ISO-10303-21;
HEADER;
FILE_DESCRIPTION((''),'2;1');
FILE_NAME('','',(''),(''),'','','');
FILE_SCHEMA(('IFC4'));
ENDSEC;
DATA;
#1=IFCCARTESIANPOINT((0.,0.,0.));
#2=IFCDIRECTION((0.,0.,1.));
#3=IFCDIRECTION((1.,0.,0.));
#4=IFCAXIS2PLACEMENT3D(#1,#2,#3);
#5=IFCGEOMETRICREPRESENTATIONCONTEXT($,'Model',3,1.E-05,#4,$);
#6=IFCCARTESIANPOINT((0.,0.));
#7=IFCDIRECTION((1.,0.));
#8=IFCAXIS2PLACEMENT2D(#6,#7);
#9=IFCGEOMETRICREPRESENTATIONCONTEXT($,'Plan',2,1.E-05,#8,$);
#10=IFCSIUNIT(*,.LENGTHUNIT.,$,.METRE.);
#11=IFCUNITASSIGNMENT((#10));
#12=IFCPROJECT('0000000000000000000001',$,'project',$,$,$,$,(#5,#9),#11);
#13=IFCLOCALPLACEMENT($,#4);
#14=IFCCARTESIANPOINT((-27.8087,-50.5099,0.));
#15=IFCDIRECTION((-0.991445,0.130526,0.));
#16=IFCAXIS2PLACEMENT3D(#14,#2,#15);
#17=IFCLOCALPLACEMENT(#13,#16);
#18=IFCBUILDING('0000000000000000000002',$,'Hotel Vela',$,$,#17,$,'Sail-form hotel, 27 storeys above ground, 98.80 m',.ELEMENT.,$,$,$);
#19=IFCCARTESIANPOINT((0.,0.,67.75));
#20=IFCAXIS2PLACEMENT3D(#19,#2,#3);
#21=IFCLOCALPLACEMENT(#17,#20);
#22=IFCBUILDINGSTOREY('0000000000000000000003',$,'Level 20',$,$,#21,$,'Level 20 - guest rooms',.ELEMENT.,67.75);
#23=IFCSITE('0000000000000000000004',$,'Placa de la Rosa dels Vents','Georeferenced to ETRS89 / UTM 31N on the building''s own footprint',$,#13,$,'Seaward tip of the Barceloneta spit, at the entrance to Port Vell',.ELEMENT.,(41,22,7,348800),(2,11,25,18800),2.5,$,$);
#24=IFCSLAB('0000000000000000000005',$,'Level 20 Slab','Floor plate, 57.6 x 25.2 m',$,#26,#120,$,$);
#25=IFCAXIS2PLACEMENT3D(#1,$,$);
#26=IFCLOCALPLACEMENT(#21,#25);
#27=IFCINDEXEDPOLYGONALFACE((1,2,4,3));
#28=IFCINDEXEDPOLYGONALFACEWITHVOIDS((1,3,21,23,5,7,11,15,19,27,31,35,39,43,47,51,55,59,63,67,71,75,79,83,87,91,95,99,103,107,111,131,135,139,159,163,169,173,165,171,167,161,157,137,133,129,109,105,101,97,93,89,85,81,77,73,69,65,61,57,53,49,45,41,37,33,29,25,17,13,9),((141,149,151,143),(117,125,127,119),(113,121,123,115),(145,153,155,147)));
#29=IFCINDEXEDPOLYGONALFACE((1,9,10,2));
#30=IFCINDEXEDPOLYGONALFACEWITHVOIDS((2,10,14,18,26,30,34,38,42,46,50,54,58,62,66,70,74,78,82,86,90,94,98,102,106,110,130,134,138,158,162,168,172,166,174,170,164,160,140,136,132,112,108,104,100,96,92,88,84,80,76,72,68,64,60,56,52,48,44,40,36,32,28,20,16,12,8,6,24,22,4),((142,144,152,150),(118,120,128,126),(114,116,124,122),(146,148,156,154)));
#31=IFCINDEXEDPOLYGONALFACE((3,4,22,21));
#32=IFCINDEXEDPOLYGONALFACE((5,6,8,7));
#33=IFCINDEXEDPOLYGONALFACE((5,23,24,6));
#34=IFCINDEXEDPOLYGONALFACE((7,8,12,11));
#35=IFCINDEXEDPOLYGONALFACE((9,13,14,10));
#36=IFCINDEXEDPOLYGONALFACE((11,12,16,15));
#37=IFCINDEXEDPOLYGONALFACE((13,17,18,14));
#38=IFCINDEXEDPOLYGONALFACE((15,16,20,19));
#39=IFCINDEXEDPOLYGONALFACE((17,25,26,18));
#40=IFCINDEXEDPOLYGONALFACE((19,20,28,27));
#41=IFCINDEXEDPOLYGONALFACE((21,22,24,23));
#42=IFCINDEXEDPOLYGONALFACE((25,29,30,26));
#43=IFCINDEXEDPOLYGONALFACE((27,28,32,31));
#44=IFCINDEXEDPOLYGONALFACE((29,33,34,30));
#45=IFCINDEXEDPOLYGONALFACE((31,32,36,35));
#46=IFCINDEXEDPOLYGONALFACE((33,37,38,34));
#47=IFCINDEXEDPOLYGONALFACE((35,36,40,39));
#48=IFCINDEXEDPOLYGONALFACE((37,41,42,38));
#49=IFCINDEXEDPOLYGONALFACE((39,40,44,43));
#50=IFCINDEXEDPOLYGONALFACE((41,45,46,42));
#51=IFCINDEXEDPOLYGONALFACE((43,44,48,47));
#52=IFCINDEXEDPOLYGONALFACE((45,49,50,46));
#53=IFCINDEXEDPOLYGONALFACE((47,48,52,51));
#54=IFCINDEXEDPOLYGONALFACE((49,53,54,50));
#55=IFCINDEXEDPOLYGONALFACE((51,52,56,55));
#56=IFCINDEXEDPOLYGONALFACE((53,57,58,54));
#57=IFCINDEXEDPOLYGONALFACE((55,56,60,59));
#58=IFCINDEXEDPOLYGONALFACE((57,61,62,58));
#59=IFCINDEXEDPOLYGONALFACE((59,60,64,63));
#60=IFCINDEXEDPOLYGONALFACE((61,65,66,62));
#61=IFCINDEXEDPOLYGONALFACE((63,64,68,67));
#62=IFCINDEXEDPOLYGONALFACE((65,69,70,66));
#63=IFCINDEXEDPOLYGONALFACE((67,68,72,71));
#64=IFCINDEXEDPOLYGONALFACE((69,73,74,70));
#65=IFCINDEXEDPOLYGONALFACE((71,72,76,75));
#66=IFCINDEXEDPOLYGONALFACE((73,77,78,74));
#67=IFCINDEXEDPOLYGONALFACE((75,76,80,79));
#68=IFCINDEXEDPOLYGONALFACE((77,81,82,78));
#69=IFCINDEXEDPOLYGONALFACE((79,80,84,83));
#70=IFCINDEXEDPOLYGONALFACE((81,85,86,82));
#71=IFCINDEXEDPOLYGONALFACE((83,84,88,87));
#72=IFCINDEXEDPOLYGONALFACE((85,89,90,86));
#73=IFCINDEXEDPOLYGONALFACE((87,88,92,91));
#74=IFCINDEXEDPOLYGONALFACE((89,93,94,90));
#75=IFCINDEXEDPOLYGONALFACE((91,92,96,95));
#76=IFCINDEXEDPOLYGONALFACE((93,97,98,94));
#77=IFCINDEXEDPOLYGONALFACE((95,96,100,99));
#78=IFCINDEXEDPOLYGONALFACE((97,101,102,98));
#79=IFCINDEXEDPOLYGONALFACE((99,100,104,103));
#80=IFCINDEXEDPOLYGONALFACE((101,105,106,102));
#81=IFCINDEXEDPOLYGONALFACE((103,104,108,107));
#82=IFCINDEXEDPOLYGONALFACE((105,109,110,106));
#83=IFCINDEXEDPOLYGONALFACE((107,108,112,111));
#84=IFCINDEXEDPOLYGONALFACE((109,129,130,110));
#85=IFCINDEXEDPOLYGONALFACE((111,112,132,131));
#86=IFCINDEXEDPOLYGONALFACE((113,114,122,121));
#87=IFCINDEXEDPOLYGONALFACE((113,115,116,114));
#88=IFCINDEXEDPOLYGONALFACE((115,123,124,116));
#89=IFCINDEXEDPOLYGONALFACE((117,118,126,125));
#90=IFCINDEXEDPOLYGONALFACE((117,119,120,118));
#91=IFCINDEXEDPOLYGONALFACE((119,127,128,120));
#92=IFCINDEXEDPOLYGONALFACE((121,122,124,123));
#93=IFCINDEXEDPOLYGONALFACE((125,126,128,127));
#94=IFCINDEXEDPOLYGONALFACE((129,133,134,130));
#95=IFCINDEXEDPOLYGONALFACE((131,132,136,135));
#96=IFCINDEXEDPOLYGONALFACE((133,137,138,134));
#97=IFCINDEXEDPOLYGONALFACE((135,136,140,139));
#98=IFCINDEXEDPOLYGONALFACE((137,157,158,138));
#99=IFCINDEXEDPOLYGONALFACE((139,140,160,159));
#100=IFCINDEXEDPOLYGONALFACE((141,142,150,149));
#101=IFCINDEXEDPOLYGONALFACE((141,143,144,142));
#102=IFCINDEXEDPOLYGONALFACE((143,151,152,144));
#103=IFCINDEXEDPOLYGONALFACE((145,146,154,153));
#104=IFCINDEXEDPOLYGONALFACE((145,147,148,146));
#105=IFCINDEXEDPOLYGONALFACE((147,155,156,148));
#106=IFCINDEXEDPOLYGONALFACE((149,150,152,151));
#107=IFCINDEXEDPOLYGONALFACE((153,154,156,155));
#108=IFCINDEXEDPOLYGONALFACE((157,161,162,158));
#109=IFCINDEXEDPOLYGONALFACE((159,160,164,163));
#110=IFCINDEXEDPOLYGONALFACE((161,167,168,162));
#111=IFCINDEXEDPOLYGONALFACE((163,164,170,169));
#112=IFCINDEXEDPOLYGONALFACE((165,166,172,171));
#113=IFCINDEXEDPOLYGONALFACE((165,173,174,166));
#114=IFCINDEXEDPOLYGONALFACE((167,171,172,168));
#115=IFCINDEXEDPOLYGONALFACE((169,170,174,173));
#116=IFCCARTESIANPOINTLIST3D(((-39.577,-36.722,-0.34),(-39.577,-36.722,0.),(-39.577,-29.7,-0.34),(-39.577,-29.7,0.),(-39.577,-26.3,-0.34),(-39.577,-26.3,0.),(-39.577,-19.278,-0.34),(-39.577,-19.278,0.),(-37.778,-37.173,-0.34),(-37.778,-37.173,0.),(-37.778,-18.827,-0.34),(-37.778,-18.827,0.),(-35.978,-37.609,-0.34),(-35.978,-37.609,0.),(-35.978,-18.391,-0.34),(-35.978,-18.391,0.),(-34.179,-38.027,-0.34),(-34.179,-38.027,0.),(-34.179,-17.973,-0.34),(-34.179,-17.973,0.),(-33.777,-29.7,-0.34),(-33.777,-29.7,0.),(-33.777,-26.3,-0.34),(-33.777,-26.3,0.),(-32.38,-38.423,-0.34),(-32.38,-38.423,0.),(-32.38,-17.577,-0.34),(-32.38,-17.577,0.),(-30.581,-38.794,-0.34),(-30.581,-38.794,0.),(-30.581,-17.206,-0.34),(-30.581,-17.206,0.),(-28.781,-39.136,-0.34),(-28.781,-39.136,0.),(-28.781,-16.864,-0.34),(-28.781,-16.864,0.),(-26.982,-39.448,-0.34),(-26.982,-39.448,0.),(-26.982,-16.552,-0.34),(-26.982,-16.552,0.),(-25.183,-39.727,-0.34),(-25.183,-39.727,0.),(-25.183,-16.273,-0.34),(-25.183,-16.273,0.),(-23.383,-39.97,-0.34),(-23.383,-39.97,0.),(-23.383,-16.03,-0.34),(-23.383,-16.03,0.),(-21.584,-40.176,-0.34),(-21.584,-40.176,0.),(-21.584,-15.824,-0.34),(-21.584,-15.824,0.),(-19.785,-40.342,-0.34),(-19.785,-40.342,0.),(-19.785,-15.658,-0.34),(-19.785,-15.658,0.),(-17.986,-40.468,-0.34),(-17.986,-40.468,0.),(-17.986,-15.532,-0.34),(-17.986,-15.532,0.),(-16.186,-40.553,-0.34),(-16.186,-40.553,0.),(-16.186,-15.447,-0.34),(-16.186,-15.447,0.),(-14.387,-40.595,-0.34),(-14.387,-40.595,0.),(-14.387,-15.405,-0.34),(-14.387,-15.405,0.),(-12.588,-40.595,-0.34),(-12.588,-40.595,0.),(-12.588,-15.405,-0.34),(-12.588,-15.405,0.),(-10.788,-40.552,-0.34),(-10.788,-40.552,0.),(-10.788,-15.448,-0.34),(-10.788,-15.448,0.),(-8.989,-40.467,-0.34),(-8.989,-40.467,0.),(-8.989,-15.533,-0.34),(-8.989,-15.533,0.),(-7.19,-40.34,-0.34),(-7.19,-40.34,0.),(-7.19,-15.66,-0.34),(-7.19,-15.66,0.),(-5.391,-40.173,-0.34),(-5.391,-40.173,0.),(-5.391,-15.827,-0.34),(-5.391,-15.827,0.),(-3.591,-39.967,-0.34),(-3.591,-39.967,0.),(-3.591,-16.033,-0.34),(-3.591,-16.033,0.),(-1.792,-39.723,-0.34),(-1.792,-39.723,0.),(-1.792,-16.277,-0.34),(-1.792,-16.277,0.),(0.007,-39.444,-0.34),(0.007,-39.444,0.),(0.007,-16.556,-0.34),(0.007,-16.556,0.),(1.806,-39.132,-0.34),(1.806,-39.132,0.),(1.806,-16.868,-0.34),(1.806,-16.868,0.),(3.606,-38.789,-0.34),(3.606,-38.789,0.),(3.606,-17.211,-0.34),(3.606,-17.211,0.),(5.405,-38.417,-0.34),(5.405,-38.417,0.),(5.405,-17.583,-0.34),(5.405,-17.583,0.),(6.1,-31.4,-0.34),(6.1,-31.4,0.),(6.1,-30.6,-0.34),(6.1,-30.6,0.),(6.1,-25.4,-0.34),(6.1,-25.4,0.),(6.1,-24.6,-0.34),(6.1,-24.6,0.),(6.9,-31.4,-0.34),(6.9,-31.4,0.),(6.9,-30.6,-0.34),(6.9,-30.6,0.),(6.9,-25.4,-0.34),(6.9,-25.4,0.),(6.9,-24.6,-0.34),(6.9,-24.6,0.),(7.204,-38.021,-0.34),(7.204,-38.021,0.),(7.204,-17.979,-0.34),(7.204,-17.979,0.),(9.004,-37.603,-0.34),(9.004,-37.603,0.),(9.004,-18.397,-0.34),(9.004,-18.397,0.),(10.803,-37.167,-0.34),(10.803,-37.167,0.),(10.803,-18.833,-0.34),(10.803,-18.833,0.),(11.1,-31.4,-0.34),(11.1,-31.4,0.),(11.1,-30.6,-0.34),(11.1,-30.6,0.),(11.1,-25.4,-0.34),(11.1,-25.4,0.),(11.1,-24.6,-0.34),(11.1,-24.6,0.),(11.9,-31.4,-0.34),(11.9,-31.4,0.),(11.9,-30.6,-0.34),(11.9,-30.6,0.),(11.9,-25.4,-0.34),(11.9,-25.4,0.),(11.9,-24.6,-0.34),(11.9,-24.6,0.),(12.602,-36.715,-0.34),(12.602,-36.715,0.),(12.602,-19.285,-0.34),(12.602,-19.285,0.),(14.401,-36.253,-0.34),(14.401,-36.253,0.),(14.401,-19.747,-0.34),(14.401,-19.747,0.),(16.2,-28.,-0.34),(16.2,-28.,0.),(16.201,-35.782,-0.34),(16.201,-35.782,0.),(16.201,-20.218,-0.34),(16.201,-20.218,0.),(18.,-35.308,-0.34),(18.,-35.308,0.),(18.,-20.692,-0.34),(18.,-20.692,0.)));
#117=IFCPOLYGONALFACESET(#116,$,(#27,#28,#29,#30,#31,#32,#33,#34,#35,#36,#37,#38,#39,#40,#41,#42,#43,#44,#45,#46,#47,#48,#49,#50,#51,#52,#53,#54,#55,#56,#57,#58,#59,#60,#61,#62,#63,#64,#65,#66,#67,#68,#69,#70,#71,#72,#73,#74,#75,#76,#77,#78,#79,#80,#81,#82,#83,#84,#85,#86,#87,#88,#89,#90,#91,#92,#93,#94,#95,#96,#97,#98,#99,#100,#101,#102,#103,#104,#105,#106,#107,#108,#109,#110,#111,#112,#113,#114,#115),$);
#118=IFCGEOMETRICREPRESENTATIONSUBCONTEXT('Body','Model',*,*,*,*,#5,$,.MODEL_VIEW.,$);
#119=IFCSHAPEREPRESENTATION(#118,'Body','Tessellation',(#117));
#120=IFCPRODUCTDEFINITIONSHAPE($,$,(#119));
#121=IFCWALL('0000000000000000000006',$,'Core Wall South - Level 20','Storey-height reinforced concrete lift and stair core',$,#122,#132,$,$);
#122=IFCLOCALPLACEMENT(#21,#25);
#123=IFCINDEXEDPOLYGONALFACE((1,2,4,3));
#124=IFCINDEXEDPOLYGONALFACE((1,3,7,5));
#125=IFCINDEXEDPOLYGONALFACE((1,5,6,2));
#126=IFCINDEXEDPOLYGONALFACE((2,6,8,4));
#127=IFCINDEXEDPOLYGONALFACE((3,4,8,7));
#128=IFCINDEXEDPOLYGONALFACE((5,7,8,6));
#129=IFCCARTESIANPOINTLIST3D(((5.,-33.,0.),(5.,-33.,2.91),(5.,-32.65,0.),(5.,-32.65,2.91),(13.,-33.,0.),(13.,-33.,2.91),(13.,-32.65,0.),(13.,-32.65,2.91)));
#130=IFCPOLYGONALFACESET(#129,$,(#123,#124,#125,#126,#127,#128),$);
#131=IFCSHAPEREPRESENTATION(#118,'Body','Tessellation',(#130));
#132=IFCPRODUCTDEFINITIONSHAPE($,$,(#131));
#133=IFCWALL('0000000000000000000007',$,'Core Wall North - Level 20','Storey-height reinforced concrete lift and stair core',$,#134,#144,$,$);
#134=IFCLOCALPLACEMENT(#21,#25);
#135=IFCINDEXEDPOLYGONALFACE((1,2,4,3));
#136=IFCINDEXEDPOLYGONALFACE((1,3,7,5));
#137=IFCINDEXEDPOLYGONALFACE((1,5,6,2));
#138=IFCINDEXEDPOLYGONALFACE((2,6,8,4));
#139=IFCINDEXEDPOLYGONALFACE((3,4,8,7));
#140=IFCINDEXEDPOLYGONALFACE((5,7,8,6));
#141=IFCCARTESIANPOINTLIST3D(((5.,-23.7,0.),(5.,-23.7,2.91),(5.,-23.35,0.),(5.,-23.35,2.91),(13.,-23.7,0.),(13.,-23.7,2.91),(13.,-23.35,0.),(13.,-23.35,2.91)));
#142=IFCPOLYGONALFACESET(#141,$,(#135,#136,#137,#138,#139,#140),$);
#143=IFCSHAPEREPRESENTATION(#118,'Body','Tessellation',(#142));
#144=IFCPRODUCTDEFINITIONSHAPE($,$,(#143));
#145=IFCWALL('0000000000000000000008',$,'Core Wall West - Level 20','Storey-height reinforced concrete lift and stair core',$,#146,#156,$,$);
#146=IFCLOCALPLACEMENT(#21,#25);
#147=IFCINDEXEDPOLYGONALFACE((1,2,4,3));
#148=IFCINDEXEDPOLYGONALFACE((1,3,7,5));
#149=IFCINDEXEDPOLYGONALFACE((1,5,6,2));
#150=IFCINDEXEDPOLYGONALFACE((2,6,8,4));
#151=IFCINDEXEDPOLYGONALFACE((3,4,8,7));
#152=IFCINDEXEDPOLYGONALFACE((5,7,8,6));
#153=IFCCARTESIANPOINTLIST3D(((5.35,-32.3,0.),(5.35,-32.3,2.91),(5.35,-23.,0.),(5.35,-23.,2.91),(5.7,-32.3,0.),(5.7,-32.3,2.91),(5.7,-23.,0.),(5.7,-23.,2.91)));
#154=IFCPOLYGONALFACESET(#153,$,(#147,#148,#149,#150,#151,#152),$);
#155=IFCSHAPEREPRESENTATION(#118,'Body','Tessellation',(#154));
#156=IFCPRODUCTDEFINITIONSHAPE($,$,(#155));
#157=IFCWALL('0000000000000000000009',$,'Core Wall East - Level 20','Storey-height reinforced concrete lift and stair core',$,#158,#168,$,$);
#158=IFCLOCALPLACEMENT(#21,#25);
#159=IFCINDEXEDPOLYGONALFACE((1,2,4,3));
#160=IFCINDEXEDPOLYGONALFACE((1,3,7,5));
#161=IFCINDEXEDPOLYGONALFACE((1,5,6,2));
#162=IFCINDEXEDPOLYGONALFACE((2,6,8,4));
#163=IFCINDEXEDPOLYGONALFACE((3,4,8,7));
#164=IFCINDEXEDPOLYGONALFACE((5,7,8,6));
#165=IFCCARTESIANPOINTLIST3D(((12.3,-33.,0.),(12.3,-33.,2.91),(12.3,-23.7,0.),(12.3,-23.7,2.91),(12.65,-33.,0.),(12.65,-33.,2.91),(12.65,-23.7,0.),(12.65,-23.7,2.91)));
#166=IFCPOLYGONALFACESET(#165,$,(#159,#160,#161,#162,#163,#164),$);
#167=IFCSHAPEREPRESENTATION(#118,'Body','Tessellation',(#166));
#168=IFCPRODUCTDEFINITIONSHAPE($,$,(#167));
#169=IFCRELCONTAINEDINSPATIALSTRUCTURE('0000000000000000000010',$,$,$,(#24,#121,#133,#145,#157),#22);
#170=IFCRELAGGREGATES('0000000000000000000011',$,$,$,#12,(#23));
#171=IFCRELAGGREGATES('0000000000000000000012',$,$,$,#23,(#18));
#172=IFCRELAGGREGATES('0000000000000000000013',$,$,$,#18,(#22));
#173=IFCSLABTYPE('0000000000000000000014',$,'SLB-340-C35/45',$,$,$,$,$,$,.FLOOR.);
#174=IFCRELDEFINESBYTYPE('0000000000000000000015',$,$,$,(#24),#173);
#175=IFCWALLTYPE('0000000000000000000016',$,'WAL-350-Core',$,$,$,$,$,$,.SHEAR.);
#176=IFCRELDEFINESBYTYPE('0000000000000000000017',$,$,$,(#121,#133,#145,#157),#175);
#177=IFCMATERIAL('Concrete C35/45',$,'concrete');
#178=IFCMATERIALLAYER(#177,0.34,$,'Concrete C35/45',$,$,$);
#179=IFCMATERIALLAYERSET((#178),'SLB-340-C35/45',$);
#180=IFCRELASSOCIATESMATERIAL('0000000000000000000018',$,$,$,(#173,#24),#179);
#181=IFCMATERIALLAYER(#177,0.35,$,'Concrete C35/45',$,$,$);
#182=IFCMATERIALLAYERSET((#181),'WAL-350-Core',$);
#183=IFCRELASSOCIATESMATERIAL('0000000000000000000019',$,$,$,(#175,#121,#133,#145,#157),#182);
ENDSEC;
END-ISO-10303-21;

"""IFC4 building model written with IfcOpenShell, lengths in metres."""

from ifc_helpers import new_model, si_unit, frame, origin_with_axes, origin_2d_with_axis, place, context, subcontext, project, spatial, line, indexed_curve, outline, extrude, material, layer, layer_set, layer_usage, type_object, element, save


model = new_model("IFC4")

# Units and contexts
model_context = context("Model", 3, precision=1e-05, world=origin_with_axes())
plan_context = context("Plan", 2, precision=1e-05, world=origin_2d_with_axis())
body_context = subcontext(model_context, "Body", "Model", "MODEL_VIEW")
ifc_project = project(units=[si_unit("LENGTHUNIT", "METRE")], contexts=[model_context, plan_context])

# Site, building, storey
site_placement = place(None, origin_with_axes())
site = spatial("IfcSite", under=ifc_project, at=site_placement, Name="Placa de la Rosa dels Vents", Description="Georeferenced to ETRS89 / UTM 31N on the building's own footprint", LongName="Seaward tip of the Barceloneta spit, at the entrance to Port Vell", CompositionType="ELEMENT", RefLatitude=(41, 22, 7, 348800), RefLongitude=(2, 11, 25, 18800), RefElevation=2.5)
building_placement = place(site_placement, frame((-27.8087, -50.5099, 0.0), z_axis=(0.0, 0.0, 1.0), x_axis=(-0.991445, 0.130526, 0.0)))
building = spatial("IfcBuilding", under=site, at=building_placement, Name="Hotel Vela", LongName="Sail-form hotel, 27 storeys above ground, 98.80 m", CompositionType="ELEMENT")
storey_placement = place(building_placement, frame((0.0, 0.0, 67.75), z_axis=(0.0, 0.0, 1.0), x_axis=(1.0, 0.0, 0.0)))
storey = spatial("IfcBuildingStorey", under=building, at=storey_placement, Name="Level 20", LongName="Level 20 - guest rooms", CompositionType="ELEMENT", Elevation=67.75)

# Shared definitions
ifc_material = material(Name="Concrete C35/45", Category="concrete")

# Slab, openings
ifc_layer_1 = layer(ifc_material, 0.34, Name="Concrete C35/45")
ifc_layer_set_1 = layer_set([ifc_layer_1], Name="SLB-340-C35/45")
ifc_layer_usage_1 = layer_usage(ifc_layer_set_1, "AXIS3", "POSITIVE", 0.0)
slab_type = type_object("IfcSlabType", Name="SLB-340-C35/45", PredefinedType="FLOOR", material=ifc_layer_set_1)
slab_placement = place(storey_placement, frame((0.0, 0.0, -0.34), z_axis=(0.0, 0.0, 1.0), x_axis=(1.0, 0.0, 0.0)))
slab = element("IfcSlab", 1, at=slab_placement, inside=storey, type_object=slab_type, material=ifc_layer_usage_1, Name="Level 20 Slab", Description="Floor plate, 57.6 x 25.2 m", context=body_context, shape_type="SweptSolid", body=[
    extrude(outline(indexed_curve([(-39.577, -36.722), (-37.778, -37.173), (-35.978, -37.609), (-34.179, -38.027), (-32.38, -38.423), (-30.581, -38.794), (-28.781, -39.136), (-26.982, -39.448), (-25.183, -39.727), (-23.383, -39.97), (-21.584, -40.176), (-19.785, -40.342), (-17.986, -40.468), (-16.186, -40.553), (-14.387, -40.595), (-12.588, -40.595), (-10.788, -40.552), (-8.989, -40.467), (-7.19, -40.34), (-5.391, -40.173), (-3.591, -39.967), (-1.792, -39.723), (0.007, -39.444), (1.806, -39.132), (3.606, -38.789), (5.405, -38.417), (7.204, -38.021), (9.004, -37.603), (10.803, -37.167), (12.602, -36.715), (14.401, -36.253), (16.201, -35.782), (18.0, -35.308), (16.2, -28.0), (18.0, -20.692), (16.201, -20.218), (14.401, -19.747), (12.602, -19.285), (10.803, -18.833), (9.004, -18.397), (7.204, -17.979), (5.405, -17.583), (3.606, -17.211), (1.806, -16.868), (0.007, -16.556), (-1.792, -16.277), (-3.591, -16.033), (-5.391, -15.827), (-7.19, -15.66), (-8.989, -15.533), (-10.788, -15.448), (-12.588, -15.405), (-14.387, -15.405), (-16.186, -15.447), (-17.986, -15.532), (-19.785, -15.658), (-21.584, -15.824), (-23.383, -16.03), (-25.183, -16.273), (-26.982, -16.552), (-28.781, -16.864), (-30.581, -17.206), (-32.38, -17.577), (-34.179, -17.973), (-35.978, -18.391), (-37.778, -18.827), (-39.577, -19.278), (-39.577, -26.3), (-33.777, -26.3), (-33.777, -29.7), (-39.577, -29.7)], segments=[line(1, 2, 3, 4, 5, 6, 7, 8, 9, 10, 11, 12, 13, 14, 15, 16, 17, 18, 19, 20, 21, 22, 23, 24, 25, 26, 27, 28, 29, 30, 31, 32, 33, 34, 35, 36, 37, 38, 39, 40, 41, 42, 43, 44, 45, 46, 47, 48, 49, 50, 51, 52, 53, 54, 55, 56, 57, 58, 59, 60, 61, 62, 63, 64, 65, 66, 67, 68, 69, 70, 71, 1)])), origin_with_axes(), (0.0, 0.0, 1.0), 0.34),
])
opening_1_placement = place(slab_placement, frame((6.1, -31.4, -0.05), z_axis=(0.0, 0.0, 1.0), x_axis=(1.0, 0.0, 0.0)))
element("IfcOpeningElement", 2, at=opening_1_placement, cuts=slab, PredefinedType="OPENING", context=body_context, shape_type="SweptSolid", body=[
    extrude(outline(indexed_curve([(0.0, 0.0), (0.8, 0.0), (0.8, 0.8), (0.0, 0.8)], segments=[line(1, 2, 3, 4, 1)])), origin_with_axes(), (0.0, 0.0, 1.0), 0.44),
])
opening_2_placement = place(slab_placement, frame((6.1, -25.4, -0.05), z_axis=(0.0, 0.0, 1.0), x_axis=(1.0, 0.0, 0.0)))
element("IfcOpeningElement", 3, at=opening_2_placement, cuts=slab, PredefinedType="OPENING", context=body_context, shape_type="SweptSolid", body=[
    extrude(outline(indexed_curve([(0.0, 0.0), (0.8, 0.0), (0.8, 0.8), (0.0, 0.8)], segments=[line(1, 2, 3, 4, 1)])), origin_with_axes(), (0.0, 0.0, 1.0), 0.44),
])
opening_3_placement = place(slab_placement, frame((11.1, -31.4, -0.05), z_axis=(0.0, 0.0, 1.0), x_axis=(1.0, 0.0, 0.0)))
element("IfcOpeningElement", 4, at=opening_3_placement, cuts=slab, PredefinedType="OPENING", context=body_context, shape_type="SweptSolid", body=[
    extrude(outline(indexed_curve([(0.0, 0.0), (0.8, 0.0), (0.8, 0.8), (0.0, 0.8)], segments=[line(1, 2, 3, 4, 1)])), origin_with_axes(), (0.0, 0.0, 1.0), 0.44),
])
opening_4_placement = place(slab_placement, frame((11.1, -25.4, -0.05), z_axis=(0.0, 0.0, 1.0), x_axis=(1.0, 0.0, 0.0)))
element("IfcOpeningElement", 5, at=opening_4_placement, cuts=slab, PredefinedType="OPENING", context=body_context, shape_type="SweptSolid", body=[
    extrude(outline(indexed_curve([(0.0, 0.0), (0.8, 0.0), (0.8, 0.8), (0.0, 0.8)], segments=[line(1, 2, 3, 4, 1)])), origin_with_axes(), (0.0, 0.0, 1.0), 0.44),
])

# Walls
ifc_layer_2 = layer(ifc_material, 0.35, Name="Concrete C35/45")
ifc_layer_set_2 = layer_set([ifc_layer_2], Name="WAL-350-Core")
ifc_layer_usage_2 = layer_usage(ifc_layer_set_2, "AXIS2", "POSITIVE", 0.0)
wall_type = type_object("IfcWallType", Name="WAL-350-Core", PredefinedType="SHEAR", material=ifc_layer_set_2)
wall_1_placement = place(storey_placement, frame((5.0, -33.0, 0.0), z_axis=(0.0, 0.0, 1.0), x_axis=(1.0, 0.0, 0.0)))
element("IfcWall", 6, at=wall_1_placement, inside=storey, type_object=wall_type, material=ifc_layer_usage_2, Name="Core Wall South - Level 20", Description="Storey-height reinforced concrete lift and stair core", context=body_context, shape_type="SweptSolid", body=[
    extrude(outline(indexed_curve([(0.0, 0.0), (8.0, 0.0), (8.0, 0.35), (0.0, 0.35)], segments=[line(1, 2, 3, 4, 1)])), origin_with_axes(), (0.0, 0.0, 1.0), 2.91),
])
ifc_layer_usage_3 = layer_usage(ifc_layer_set_2, "AXIS2", "POSITIVE", 0.0)
wall_2_placement = place(storey_placement, frame((13.0, -23.35, 0.0), z_axis=(0.0, 0.0, 1.0), x_axis=(-1.0, 0.0, 0.0)))
element("IfcWall", 7, at=wall_2_placement, inside=storey, type_object=wall_type, material=ifc_layer_usage_3, Name="Core Wall North - Level 20", Description="Storey-height reinforced concrete lift and stair core", context=body_context, shape_type="SweptSolid", body=[
    extrude(outline(indexed_curve([(0.0, 0.0), (8.0, 0.0), (8.0, 0.35), (0.0, 0.35)], segments=[line(1, 2, 3, 4, 1)])), origin_with_axes(), (0.0, 0.0, 1.0), 2.91),
])
ifc_layer_usage_4 = layer_usage(ifc_layer_set_2, "AXIS2", "POSITIVE", 0.0)
wall_3_placement = place(storey_placement, frame((5.35, -23.0, 0.0), z_axis=(0.0, 0.0, 1.0), x_axis=(0.0, -1.0, 0.0)))
element("IfcWall", 8, at=wall_3_placement, inside=storey, type_object=wall_type, material=ifc_layer_usage_4, Name="Core Wall West - Level 20", Description="Storey-height reinforced concrete lift and stair core", context=body_context, shape_type="SweptSolid", body=[
    extrude(outline(indexed_curve([(0.0, 0.0), (9.3, 0.0), (9.3, 0.35), (0.0, 0.35)], segments=[line(1, 2, 3, 4, 1)])), origin_with_axes(), (0.0, 0.0, 1.0), 2.91),
])
ifc_layer_usage_5 = layer_usage(ifc_layer_set_2, "AXIS2", "POSITIVE", 0.0)
wall_4_placement = place(storey_placement, frame((12.65, -33.0, 0.0), z_axis=(0.0, 0.0, 1.0), x_axis=(0.0, 1.0, 0.0)))
element("IfcWall", 9, at=wall_4_placement, inside=storey, type_object=wall_type, material=ifc_layer_usage_5, Name="Core Wall East - Level 20", Description="Storey-height reinforced concrete lift and stair core", context=body_context, shape_type="SweptSolid", body=[
    extrude(outline(indexed_curve([(0.0, 0.0), (9.3, 0.0), (9.3, 0.35), (0.0, 0.35)], segments=[line(1, 2, 3, 4, 1)])), origin_with_axes(), (0.0, 0.0, 1.0), 2.91),
])

save(model, "model.ifc")
